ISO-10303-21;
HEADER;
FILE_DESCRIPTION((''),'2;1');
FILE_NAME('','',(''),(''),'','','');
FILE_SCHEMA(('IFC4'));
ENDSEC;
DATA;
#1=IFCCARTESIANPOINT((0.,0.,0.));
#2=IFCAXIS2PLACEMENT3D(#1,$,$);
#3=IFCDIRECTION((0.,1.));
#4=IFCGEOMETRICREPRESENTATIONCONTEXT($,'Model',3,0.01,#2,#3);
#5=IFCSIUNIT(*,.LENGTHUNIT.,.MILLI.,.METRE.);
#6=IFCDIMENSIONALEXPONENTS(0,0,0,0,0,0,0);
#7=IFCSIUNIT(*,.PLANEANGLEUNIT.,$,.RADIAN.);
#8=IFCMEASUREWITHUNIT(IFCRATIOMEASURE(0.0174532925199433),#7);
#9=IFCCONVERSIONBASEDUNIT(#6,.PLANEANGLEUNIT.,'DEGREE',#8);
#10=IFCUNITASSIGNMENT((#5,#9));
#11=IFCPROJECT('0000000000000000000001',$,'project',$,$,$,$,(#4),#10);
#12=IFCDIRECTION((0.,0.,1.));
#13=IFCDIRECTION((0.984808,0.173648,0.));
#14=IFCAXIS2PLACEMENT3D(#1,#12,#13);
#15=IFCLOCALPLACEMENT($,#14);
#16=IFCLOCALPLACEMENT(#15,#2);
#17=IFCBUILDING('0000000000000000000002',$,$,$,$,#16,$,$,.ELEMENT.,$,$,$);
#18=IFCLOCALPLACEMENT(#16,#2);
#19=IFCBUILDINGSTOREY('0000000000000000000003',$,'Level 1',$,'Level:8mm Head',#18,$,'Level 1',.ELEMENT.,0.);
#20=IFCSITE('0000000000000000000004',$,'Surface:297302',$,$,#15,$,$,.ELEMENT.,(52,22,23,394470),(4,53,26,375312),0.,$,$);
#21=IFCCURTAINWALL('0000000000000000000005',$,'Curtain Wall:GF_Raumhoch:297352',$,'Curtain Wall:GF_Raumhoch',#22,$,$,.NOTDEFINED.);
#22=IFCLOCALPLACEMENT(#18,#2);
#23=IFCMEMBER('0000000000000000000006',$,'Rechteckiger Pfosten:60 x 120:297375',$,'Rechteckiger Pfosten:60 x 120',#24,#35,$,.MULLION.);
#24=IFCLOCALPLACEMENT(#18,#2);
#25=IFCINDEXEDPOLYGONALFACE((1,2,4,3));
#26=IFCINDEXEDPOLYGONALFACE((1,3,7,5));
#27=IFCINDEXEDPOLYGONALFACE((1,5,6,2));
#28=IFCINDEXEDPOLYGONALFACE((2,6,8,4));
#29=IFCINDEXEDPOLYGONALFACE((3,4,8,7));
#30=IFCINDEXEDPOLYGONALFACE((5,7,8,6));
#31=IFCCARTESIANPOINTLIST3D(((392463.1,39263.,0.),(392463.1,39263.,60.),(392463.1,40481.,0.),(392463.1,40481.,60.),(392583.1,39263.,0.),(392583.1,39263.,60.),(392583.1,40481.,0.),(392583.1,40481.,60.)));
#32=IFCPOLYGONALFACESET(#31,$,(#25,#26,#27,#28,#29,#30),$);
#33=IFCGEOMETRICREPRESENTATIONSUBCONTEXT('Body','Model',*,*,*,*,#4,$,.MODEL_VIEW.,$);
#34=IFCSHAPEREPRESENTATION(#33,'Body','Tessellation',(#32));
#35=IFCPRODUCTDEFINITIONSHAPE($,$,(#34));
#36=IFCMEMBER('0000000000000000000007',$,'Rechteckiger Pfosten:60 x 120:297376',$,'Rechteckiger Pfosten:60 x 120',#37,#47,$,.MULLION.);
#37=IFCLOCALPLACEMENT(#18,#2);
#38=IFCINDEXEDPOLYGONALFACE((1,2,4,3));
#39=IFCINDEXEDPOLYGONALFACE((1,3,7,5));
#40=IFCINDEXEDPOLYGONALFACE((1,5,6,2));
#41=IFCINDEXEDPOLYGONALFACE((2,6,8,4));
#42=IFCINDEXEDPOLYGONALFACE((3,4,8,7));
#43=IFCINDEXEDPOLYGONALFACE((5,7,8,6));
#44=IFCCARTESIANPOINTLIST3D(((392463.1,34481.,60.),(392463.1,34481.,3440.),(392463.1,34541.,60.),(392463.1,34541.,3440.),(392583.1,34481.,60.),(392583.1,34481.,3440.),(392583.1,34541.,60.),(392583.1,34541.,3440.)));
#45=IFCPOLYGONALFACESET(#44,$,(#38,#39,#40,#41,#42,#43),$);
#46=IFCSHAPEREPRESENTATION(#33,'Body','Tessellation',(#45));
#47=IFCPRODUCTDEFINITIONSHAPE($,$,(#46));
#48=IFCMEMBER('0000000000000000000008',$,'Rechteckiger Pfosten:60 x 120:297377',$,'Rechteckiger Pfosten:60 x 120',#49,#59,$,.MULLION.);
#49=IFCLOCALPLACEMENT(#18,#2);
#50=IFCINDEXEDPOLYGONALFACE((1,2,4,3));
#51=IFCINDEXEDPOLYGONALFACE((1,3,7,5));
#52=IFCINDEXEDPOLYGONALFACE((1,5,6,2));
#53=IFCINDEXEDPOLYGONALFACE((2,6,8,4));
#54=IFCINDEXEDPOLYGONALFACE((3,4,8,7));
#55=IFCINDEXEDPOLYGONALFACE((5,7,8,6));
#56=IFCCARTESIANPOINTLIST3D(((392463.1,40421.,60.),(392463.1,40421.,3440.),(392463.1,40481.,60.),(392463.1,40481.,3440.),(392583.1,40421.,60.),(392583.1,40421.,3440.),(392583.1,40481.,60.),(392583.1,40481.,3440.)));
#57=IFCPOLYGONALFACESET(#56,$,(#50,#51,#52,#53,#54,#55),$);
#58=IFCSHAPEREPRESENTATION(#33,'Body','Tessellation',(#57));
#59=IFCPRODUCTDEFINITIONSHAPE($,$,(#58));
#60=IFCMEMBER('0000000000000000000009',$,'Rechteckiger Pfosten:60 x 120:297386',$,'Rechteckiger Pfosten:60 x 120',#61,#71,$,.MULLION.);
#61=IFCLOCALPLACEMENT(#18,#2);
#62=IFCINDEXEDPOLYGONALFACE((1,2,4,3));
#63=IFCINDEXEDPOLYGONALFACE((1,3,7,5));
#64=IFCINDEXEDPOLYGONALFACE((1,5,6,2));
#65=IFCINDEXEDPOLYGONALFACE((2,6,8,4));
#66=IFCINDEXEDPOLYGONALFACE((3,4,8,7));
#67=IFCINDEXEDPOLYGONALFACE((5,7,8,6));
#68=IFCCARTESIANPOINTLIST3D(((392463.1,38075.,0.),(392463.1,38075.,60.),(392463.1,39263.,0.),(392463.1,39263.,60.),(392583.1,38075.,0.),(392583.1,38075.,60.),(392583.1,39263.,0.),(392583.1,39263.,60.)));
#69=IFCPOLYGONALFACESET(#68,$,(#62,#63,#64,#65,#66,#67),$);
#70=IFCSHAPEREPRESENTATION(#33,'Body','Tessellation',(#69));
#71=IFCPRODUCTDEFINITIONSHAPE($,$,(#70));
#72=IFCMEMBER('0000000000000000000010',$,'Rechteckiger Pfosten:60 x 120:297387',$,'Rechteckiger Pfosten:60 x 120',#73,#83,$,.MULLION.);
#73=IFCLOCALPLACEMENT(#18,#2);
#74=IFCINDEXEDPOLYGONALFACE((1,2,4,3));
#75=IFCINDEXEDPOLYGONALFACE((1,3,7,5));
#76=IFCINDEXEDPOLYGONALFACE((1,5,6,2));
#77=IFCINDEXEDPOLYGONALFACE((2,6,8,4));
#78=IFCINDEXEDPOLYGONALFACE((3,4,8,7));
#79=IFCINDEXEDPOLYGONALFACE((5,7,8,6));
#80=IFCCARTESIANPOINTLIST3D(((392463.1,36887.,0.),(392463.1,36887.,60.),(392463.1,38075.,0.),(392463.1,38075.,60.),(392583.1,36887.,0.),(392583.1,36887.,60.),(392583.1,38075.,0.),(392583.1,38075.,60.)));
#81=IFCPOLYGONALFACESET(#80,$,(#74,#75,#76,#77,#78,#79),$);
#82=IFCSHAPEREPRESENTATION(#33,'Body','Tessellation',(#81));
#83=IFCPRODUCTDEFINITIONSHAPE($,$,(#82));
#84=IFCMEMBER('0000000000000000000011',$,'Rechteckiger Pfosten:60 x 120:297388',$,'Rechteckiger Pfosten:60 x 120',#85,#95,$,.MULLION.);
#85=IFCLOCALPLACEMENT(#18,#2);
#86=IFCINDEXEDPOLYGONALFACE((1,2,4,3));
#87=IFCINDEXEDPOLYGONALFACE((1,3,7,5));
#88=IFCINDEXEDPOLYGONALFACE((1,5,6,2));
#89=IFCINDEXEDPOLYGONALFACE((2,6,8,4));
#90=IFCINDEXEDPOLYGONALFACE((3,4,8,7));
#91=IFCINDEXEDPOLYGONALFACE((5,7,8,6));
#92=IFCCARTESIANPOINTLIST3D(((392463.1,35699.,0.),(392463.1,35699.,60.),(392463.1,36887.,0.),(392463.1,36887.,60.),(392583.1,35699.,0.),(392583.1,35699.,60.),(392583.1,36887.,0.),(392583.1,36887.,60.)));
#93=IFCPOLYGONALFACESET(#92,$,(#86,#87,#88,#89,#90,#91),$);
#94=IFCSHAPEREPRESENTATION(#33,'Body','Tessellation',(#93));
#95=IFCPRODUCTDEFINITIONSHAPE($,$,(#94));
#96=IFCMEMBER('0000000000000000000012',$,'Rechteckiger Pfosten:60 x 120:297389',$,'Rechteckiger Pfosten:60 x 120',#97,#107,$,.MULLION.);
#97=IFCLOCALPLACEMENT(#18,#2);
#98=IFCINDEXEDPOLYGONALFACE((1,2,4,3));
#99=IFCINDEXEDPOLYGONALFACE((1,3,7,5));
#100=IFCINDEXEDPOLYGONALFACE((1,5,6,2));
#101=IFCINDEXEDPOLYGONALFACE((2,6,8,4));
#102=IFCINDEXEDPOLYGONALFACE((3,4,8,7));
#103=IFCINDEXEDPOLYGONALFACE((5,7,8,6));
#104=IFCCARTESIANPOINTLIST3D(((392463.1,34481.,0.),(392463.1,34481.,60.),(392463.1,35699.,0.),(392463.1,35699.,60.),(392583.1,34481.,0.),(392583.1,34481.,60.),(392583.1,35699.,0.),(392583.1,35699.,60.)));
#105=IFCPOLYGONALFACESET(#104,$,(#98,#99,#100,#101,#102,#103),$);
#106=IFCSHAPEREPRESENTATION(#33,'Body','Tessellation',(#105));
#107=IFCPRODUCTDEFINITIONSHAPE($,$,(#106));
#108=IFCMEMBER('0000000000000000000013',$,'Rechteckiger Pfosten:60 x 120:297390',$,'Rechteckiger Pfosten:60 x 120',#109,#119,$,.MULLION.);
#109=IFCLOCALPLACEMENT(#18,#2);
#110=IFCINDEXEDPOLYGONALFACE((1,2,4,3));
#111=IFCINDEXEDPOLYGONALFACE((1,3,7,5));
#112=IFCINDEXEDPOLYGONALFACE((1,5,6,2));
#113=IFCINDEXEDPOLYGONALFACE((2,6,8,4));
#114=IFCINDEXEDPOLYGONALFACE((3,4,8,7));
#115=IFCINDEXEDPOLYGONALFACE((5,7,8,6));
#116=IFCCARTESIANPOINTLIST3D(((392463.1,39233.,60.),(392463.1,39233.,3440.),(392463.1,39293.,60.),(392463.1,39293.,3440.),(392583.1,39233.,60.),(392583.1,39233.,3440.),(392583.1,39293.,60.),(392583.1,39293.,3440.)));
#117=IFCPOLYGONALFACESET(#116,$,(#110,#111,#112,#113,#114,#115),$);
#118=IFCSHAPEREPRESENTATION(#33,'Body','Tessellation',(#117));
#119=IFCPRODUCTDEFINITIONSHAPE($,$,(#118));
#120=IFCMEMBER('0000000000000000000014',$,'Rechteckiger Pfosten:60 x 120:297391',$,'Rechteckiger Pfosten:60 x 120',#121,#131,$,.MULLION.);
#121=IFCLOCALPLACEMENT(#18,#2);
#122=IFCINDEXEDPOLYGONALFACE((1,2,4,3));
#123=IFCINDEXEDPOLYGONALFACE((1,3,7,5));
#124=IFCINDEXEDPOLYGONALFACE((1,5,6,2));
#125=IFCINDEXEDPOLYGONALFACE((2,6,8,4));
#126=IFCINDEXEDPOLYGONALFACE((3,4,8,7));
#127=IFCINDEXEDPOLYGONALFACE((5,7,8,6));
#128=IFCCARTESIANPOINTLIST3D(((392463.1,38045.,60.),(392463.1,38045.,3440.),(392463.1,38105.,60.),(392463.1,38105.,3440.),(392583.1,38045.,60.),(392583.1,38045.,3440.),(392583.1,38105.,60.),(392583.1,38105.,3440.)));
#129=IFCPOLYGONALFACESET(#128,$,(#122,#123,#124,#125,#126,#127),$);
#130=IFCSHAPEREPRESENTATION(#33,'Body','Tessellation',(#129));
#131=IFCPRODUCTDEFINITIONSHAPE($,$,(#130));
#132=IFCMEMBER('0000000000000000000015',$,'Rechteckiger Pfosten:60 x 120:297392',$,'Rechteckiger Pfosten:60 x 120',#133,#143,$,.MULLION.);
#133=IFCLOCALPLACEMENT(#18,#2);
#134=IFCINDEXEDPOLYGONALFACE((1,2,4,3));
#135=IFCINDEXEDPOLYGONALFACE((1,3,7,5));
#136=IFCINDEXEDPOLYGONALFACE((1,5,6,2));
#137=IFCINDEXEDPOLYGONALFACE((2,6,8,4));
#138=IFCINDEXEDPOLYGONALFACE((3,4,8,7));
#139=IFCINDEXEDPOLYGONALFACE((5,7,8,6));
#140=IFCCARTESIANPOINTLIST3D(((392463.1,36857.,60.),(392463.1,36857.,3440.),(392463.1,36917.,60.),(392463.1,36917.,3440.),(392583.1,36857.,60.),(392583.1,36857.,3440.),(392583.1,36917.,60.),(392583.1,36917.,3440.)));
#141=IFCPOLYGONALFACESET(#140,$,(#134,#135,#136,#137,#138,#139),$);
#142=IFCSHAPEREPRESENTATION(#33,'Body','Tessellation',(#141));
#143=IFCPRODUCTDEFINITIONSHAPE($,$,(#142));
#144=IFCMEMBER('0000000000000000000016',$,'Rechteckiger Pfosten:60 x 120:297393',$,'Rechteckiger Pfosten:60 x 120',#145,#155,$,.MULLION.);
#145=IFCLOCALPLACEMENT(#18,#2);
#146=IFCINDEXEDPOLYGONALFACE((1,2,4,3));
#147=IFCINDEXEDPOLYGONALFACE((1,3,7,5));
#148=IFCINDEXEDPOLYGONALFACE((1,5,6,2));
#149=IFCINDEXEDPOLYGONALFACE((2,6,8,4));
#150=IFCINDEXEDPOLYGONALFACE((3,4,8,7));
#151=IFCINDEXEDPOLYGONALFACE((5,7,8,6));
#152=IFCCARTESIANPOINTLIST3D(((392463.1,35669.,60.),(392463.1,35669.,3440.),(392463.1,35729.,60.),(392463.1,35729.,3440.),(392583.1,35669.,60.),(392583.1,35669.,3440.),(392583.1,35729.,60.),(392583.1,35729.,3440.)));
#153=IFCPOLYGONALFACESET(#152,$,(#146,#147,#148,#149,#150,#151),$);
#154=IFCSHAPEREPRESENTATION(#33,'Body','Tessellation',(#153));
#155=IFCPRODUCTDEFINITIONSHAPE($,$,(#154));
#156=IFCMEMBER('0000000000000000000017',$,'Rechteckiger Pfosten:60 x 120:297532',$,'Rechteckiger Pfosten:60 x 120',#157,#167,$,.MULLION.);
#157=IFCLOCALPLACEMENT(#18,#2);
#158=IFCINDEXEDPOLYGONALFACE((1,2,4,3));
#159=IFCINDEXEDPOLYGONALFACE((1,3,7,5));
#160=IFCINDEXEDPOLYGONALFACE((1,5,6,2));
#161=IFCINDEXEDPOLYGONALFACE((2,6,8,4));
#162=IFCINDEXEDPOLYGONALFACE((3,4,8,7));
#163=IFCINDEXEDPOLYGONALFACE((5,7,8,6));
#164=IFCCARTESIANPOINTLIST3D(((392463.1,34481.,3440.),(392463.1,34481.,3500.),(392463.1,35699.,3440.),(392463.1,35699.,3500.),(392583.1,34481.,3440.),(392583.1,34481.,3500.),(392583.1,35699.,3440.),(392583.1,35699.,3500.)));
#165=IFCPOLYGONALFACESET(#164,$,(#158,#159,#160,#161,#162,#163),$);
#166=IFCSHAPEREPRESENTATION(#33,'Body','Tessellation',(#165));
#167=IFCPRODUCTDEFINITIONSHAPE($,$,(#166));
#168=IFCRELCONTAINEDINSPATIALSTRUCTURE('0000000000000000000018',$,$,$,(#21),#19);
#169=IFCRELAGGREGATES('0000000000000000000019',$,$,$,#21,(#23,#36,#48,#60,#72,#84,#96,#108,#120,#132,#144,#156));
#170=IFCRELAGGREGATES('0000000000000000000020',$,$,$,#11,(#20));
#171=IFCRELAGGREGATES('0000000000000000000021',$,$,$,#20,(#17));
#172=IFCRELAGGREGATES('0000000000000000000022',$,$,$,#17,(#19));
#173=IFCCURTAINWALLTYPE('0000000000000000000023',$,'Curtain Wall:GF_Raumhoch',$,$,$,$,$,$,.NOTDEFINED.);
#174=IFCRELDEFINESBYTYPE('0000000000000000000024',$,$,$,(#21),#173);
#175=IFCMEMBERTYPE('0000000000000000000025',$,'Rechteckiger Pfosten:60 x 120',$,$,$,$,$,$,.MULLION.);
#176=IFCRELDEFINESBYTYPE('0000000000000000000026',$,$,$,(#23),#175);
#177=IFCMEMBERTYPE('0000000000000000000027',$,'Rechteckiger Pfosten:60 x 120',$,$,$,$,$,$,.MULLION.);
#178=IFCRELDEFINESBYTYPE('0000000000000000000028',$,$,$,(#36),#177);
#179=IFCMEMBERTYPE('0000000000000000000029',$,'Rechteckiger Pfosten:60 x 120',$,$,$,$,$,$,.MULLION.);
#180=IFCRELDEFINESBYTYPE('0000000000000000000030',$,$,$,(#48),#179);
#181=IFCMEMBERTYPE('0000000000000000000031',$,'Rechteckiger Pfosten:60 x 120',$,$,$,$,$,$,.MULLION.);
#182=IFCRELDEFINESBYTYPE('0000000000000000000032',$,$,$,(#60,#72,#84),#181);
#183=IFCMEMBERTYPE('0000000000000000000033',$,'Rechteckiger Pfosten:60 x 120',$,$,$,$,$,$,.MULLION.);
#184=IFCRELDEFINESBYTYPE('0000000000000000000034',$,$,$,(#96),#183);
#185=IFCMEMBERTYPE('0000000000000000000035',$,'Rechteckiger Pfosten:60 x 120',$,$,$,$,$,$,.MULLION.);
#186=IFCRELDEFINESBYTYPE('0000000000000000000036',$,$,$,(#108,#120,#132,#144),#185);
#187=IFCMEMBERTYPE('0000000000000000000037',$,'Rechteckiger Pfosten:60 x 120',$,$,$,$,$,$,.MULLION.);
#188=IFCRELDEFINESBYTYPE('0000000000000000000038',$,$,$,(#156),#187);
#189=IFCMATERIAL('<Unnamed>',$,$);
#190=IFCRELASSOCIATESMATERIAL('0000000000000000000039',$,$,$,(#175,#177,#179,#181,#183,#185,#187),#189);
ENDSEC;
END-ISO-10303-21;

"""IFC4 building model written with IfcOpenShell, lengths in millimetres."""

from ifc_helpers import new_model, entity, si_unit, converted_unit, direction, frame, origin, place, context, subcontext, project, spatial, indexed_curve, outline, extrude, source, transform, mapped, material, type_object, type_shapes, element, aggregate, save


model = new_model("IFC4")

# Units and contexts
model_context = context("Model", 3, precision=0.01, world=origin(), true_north=direction((0.0, 1.0)))
body_context = subcontext(model_context, "Body", "Model", "MODEL_VIEW")
ifc_project = project(units=[si_unit("LENGTHUNIT", "METRE", prefix="MILLI"), converted_unit("PLANEANGLEUNIT", "DEGREE", entity("IfcRatioMeasure", 0.0174532925199433), si_unit("PLANEANGLEUNIT", "RADIAN"), dimensions=[0, 0, 0, 0, 0, 0, 0])], contexts=[model_context])

# Site, building, storey
site_placement = place(None, frame((0.0, 0.0, 0.0), z_axis=(0.0, 0.0, 1.0), x_axis=(0.984808, 0.173648, 0.0)))
site = spatial("IfcSite", under=ifc_project, at=site_placement, Name="Surface:297302", CompositionType="ELEMENT", RefLatitude=(52, 22, 23, 394470), RefLongitude=(4, 53, 26, 375312), RefElevation=0.0)
building_placement = place(site_placement, origin())
building = spatial("IfcBuilding", under=site, at=building_placement, CompositionType="ELEMENT")
storey_placement = place(building_placement, origin())
storey = spatial("IfcBuildingStorey", under=building, at=storey_placement, Name="Level 1", ObjectType="Level:8mm Head", LongName="Level 1", CompositionType="ELEMENT", Elevation=0.0)

# Curtain wall, members
curtain_wall_type = type_object("IfcCurtainWallType", Name="Curtain Wall:GF_Raumhoch", PredefinedType="NOTDEFINED")
curtain_wall_placement = place(storey_placement, origin())
curtain_wall = element("IfcCurtainWall", 1, at=curtain_wall_placement, inside=storey, type_object=curtain_wall_type, Name="Curtain Wall:GF_Raumhoch:297352", ObjectType="Curtain Wall:GF_Raumhoch", PredefinedType="NOTDEFINED")
ifc_material_1 = material(Name="<Unnamed>")
member_type_1 = type_object("IfcMemberType", Name="Rechteckiger Pfosten:60 x 120", PredefinedType="MULLION", material=ifc_material_1)
shared_shape_1 = source(origin(), body_context, "Body", "SweptSolid", [
    extrude(outline(indexed_curve([(-60.0, -30.0), (60.0, -30.0), (60.0, 30.0), (-60.0, 30.0), (-60.0, -30.0)], self_intersect=False)), frame((-30.0, 0.0, -1218.0), z_axis=(0.0, 0.0, 1.0), x_axis=(0.0, -1.0, 0.0)), (0.0, 0.0, 1.0), 1218.0),
])
type_shapes(member_type_1, [shared_shape_1])
member_1_placement = place(curtain_wall_placement, frame((392523.1, 40481.0, 0.0), z_axis=(0.0, 1.0, 0.0), x_axis=(0.0, 0.0, -1.0)))
member_1 = element("IfcMember", 2, at=member_1_placement, type_object=member_type_1, Name="Rechteckiger Pfosten:60 x 120:297375", ObjectType="Rechteckiger Pfosten:60 x 120", PredefinedType="MULLION", context=body_context, shape_type="MappedRepresentation", body=[
    mapped(shared_shape_1, transform((0.0, 0.0, 0.0), scale=1.0)),
])
member_type_2 = type_object("IfcMemberType", Name="Rechteckiger Pfosten:60 x 120", PredefinedType="MULLION", material=ifc_material_1)
shared_shape_2 = source(origin(), body_context, "Body", "SweptSolid", [
    extrude(outline(indexed_curve([(-60.0, -30.0), (60.0, -30.0), (60.0, 30.0), (-60.0, 30.0), (-60.0, -30.0)], self_intersect=False)), frame((-30.0, 0.0, -3380.0), z_axis=(0.0, 0.0, 1.0), x_axis=(0.0, -1.0, 0.0)), (0.0, 0.0, 1.0), 3380.0),
])
type_shapes(member_type_2, [shared_shape_2])
member_2_placement = place(curtain_wall_placement, frame((392523.1, 34481.0, 60.0), z_axis=(0.0, 0.0, -1.0), x_axis=(0.0, -1.0, 0.0)))
member_2 = element("IfcMember", 3, at=member_2_placement, type_object=member_type_2, Name="Rechteckiger Pfosten:60 x 120:297376", ObjectType="Rechteckiger Pfosten:60 x 120", PredefinedType="MULLION", context=body_context, shape_type="MappedRepresentation", body=[
    mapped(shared_shape_2, transform((0.0, 0.0, 0.0), scale=1.0)),
])
member_type_3 = type_object("IfcMemberType", Name="Rechteckiger Pfosten:60 x 120", PredefinedType="MULLION", material=ifc_material_1)
shared_shape_3 = source(origin(), body_context, "Body", "SweptSolid", [
    extrude(outline(indexed_curve([(-60.0, -30.0), (60.0, -30.0), (60.0, 30.0), (-60.0, 30.0), (-60.0, -30.0)], self_intersect=False)), frame((-30.0, 0.0, -3380.0), z_axis=(0.0, 0.0, 1.0), x_axis=(0.0, -1.0, 0.0)), (0.0, 0.0, 1.0), 3380.0),
])
type_shapes(member_type_3, [shared_shape_3])
member_3_placement = place(curtain_wall_placement, frame((392523.1, 40481.0, 3440.0), z_axis=(0.0, 0.0, 1.0), x_axis=(0.0, 1.0, 0.0)))
member_3 = element("IfcMember", 4, at=member_3_placement, type_object=member_type_3, Name="Rechteckiger Pfosten:60 x 120:297377", ObjectType="Rechteckiger Pfosten:60 x 120", PredefinedType="MULLION", context=body_context, shape_type="MappedRepresentation", body=[
    mapped(shared_shape_3, transform((0.0, 0.0, 0.0), scale=1.0)),
])
member_type_4 = type_object("IfcMemberType", Name="Rechteckiger Pfosten:60 x 120", PredefinedType="MULLION", material=ifc_material_1)
shared_shape_4 = source(origin(), body_context, "Body", "SweptSolid", [
    extrude(outline(indexed_curve([(-60.0, -30.0), (60.0, -30.0), (60.0, 30.0), (-60.0, 30.0), (-60.0, -30.0)], self_intersect=False)), frame((-30.0, 0.0, -1188.0), z_axis=(0.0, 0.0, 1.0), x_axis=(0.0, -1.0, 0.0)), (0.0, 0.0, 1.0), 1188.0),
])
type_shapes(member_type_4, [shared_shape_4])
member_4_placement = place(curtain_wall_placement, frame((392523.1, 39263.0, 0.0), z_axis=(0.0, 1.0, 0.0), x_axis=(0.0, 0.0, -1.0)))
member_4 = element("IfcMember", 5, at=member_4_placement, type_object=member_type_4, Name="Rechteckiger Pfosten:60 x 120:297386", ObjectType="Rechteckiger Pfosten:60 x 120", PredefinedType="MULLION", context=body_context, shape_type="MappedRepresentation", body=[
    mapped(shared_shape_4, transform((0.0, 0.0, 0.0), scale=1.0)),
])
member_5_placement = place(curtain_wall_placement, frame((392523.1, 38075.0, 0.0), z_axis=(0.0, 1.0, 0.0), x_axis=(0.0, 0.0, -1.0)))
member_5 = element("IfcMember", 6, at=member_5_placement, type_object=member_type_4, Name="Rechteckiger Pfosten:60 x 120:297387", ObjectType="Rechteckiger Pfosten:60 x 120", PredefinedType="MULLION", context=body_context, shape_type="MappedRepresentation", body=[
    mapped(shared_shape_4, transform((0.0, 0.0, 0.0), scale=1.0)),
])
member_6_placement = place(curtain_wall_placement, frame((392523.1, 36887.0, 0.0), z_axis=(0.0, 1.0, 0.0), x_axis=(0.0, 0.0, -1.0)))
member_6 = element("IfcMember", 7, at=member_6_placement, type_object=member_type_4, Name="Rechteckiger Pfosten:60 x 120:297388", ObjectType="Rechteckiger Pfosten:60 x 120", PredefinedType="MULLION", context=body_context, shape_type="MappedRepresentation", body=[
    mapped(shared_shape_4, transform((0.0, 0.0, 0.0), scale=1.0)),
])
member_type_5 = type_object("IfcMemberType", Name="Rechteckiger Pfosten:60 x 120", PredefinedType="MULLION", material=ifc_material_1)
shared_shape_5 = source(origin(), body_context, "Body", "SweptSolid", [
    extrude(outline(indexed_curve([(-60.0, -30.0), (60.0, -30.0), (60.0, 30.0), (-60.0, 30.0), (-60.0, -30.0)], self_intersect=False)), frame((-30.0, 0.0, -1218.0), z_axis=(0.0, 0.0, 1.0), x_axis=(0.0, -1.0, 0.0)), (0.0, 0.0, 1.0), 1218.0),
])
type_shapes(member_type_5, [shared_shape_5])
member_7_placement = place(curtain_wall_placement, frame((392523.1, 35699.0, 0.0), z_axis=(0.0, 1.0, 0.0), x_axis=(0.0, 0.0, -1.0)))
member_7 = element("IfcMember", 8, at=member_7_placement, type_object=member_type_5, Name="Rechteckiger Pfosten:60 x 120:297389", ObjectType="Rechteckiger Pfosten:60 x 120", PredefinedType="MULLION", context=body_context, shape_type="MappedRepresentation", body=[
    mapped(shared_shape_5, transform((0.0, 0.0, 0.0), scale=1.0)),
])
member_type_6 = type_object("IfcMemberType", Name="Rechteckiger Pfosten:60 x 120", PredefinedType="MULLION", material=ifc_material_1)
shared_shape_6 = source(origin(), body_context, "Body", "SweptSolid", [
    extrude(outline(indexed_curve([(-60.0, -30.0), (60.0, -30.0), (60.0, 30.0), (-60.0, 30.0), (-60.0, -30.0)], self_intersect=False)), frame((0.0, 0.0, -3380.0), z_axis=(0.0, 0.0, 1.0), x_axis=(0.0, -1.0, 0.0)), (0.0, 0.0, 1.0), 3380.0),
])
type_shapes(member_type_6, [shared_shape_6])
member_8_placement = place(curtain_wall_placement, frame((392523.1, 39263.0, 60.0), z_axis=(0.0, 0.0, -1.0), x_axis=(0.0, -1.0, 0.0)))
member_8 = element("IfcMember", 9, at=member_8_placement, type_object=member_type_6, Name="Rechteckiger Pfosten:60 x 120:297390", ObjectType="Rechteckiger Pfosten:60 x 120", PredefinedType="MULLION", context=body_context, shape_type="MappedRepresentation", body=[
    mapped(shared_shape_6, transform((0.0, 0.0, 0.0), scale=1.0)),
])
member_9_placement = place(curtain_wall_placement, frame((392523.1, 38075.0, 60.0), z_axis=(0.0, 0.0, -1.0), x_axis=(0.0, -1.0, 0.0)))
member_9 = element("IfcMember", 10, at=member_9_placement, type_object=member_type_6, Name="Rechteckiger Pfosten:60 x 120:297391", ObjectType="Rechteckiger Pfosten:60 x 120", PredefinedType="MULLION", context=body_context, shape_type="MappedRepresentation", body=[
    mapped(shared_shape_6, transform((0.0, 0.0, 0.0), scale=1.0)),
])
member_10_placement = place(curtain_wall_placement, frame((392523.1, 36887.0, 60.0), z_axis=(0.0, 0.0, -1.0), x_axis=(0.0, -1.0, 0.0)))
member_10 = element("IfcMember", 11, at=member_10_placement, type_object=member_type_6, Name="Rechteckiger Pfosten:60 x 120:297392", ObjectType="Rechteckiger Pfosten:60 x 120", PredefinedType="MULLION", context=body_context, shape_type="MappedRepresentation", body=[
    mapped(shared_shape_6, transform((0.0, 0.0, 0.0), scale=1.0)),
])
member_11_placement = place(curtain_wall_placement, frame((392523.1, 35699.0, 60.0), z_axis=(0.0, 0.0, -1.0), x_axis=(0.0, -1.0, 0.0)))
member_11 = element("IfcMember", 12, at=member_11_placement, type_object=member_type_6, Name="Rechteckiger Pfosten:60 x 120:297393", ObjectType="Rechteckiger Pfosten:60 x 120", PredefinedType="MULLION", context=body_context, shape_type="MappedRepresentation", body=[
    mapped(shared_shape_6, transform((0.0, 0.0, 0.0), scale=1.0)),
])
member_type_7 = type_object("IfcMemberType", Name="Rechteckiger Pfosten:60 x 120", PredefinedType="MULLION", material=ifc_material_1)
shared_shape_7 = source(origin(), body_context, "Body", "SweptSolid", [
    extrude(outline(indexed_curve([(-60.0, -30.0), (60.0, -30.0), (60.0, 30.0), (-60.0, 30.0), (-60.0, -30.0)], self_intersect=False)), frame((-30.0, 0.0, -1218.0), z_axis=(0.0, 0.0, 1.0), x_axis=(0.0, -1.0, 0.0)), (0.0, 0.0, 1.0), 1218.0),
])
type_shapes(member_type_7, [shared_shape_7])
member_12_placement = place(curtain_wall_placement, frame((392523.1, 34481.0, 3500.0), z_axis=(0.0, -1.0, 0.0), x_axis=(0.0, 0.0, 1.0)))
member_12 = element("IfcMember", 13, at=member_12_placement, type_object=member_type_7, Name="Rechteckiger Pfosten:60 x 120:297532", ObjectType="Rechteckiger Pfosten:60 x 120", PredefinedType="MULLION", context=body_context, shape_type="MappedRepresentation", body=[
    mapped(shared_shape_7, transform((0.0, 0.0, 0.0), scale=1.0)),
])

aggregate(curtain_wall, [member_1, member_2, member_3, member_4, member_5, member_6, member_7, member_8, member_9, member_10, member_11, member_12])

save(model, "model.ifc")
